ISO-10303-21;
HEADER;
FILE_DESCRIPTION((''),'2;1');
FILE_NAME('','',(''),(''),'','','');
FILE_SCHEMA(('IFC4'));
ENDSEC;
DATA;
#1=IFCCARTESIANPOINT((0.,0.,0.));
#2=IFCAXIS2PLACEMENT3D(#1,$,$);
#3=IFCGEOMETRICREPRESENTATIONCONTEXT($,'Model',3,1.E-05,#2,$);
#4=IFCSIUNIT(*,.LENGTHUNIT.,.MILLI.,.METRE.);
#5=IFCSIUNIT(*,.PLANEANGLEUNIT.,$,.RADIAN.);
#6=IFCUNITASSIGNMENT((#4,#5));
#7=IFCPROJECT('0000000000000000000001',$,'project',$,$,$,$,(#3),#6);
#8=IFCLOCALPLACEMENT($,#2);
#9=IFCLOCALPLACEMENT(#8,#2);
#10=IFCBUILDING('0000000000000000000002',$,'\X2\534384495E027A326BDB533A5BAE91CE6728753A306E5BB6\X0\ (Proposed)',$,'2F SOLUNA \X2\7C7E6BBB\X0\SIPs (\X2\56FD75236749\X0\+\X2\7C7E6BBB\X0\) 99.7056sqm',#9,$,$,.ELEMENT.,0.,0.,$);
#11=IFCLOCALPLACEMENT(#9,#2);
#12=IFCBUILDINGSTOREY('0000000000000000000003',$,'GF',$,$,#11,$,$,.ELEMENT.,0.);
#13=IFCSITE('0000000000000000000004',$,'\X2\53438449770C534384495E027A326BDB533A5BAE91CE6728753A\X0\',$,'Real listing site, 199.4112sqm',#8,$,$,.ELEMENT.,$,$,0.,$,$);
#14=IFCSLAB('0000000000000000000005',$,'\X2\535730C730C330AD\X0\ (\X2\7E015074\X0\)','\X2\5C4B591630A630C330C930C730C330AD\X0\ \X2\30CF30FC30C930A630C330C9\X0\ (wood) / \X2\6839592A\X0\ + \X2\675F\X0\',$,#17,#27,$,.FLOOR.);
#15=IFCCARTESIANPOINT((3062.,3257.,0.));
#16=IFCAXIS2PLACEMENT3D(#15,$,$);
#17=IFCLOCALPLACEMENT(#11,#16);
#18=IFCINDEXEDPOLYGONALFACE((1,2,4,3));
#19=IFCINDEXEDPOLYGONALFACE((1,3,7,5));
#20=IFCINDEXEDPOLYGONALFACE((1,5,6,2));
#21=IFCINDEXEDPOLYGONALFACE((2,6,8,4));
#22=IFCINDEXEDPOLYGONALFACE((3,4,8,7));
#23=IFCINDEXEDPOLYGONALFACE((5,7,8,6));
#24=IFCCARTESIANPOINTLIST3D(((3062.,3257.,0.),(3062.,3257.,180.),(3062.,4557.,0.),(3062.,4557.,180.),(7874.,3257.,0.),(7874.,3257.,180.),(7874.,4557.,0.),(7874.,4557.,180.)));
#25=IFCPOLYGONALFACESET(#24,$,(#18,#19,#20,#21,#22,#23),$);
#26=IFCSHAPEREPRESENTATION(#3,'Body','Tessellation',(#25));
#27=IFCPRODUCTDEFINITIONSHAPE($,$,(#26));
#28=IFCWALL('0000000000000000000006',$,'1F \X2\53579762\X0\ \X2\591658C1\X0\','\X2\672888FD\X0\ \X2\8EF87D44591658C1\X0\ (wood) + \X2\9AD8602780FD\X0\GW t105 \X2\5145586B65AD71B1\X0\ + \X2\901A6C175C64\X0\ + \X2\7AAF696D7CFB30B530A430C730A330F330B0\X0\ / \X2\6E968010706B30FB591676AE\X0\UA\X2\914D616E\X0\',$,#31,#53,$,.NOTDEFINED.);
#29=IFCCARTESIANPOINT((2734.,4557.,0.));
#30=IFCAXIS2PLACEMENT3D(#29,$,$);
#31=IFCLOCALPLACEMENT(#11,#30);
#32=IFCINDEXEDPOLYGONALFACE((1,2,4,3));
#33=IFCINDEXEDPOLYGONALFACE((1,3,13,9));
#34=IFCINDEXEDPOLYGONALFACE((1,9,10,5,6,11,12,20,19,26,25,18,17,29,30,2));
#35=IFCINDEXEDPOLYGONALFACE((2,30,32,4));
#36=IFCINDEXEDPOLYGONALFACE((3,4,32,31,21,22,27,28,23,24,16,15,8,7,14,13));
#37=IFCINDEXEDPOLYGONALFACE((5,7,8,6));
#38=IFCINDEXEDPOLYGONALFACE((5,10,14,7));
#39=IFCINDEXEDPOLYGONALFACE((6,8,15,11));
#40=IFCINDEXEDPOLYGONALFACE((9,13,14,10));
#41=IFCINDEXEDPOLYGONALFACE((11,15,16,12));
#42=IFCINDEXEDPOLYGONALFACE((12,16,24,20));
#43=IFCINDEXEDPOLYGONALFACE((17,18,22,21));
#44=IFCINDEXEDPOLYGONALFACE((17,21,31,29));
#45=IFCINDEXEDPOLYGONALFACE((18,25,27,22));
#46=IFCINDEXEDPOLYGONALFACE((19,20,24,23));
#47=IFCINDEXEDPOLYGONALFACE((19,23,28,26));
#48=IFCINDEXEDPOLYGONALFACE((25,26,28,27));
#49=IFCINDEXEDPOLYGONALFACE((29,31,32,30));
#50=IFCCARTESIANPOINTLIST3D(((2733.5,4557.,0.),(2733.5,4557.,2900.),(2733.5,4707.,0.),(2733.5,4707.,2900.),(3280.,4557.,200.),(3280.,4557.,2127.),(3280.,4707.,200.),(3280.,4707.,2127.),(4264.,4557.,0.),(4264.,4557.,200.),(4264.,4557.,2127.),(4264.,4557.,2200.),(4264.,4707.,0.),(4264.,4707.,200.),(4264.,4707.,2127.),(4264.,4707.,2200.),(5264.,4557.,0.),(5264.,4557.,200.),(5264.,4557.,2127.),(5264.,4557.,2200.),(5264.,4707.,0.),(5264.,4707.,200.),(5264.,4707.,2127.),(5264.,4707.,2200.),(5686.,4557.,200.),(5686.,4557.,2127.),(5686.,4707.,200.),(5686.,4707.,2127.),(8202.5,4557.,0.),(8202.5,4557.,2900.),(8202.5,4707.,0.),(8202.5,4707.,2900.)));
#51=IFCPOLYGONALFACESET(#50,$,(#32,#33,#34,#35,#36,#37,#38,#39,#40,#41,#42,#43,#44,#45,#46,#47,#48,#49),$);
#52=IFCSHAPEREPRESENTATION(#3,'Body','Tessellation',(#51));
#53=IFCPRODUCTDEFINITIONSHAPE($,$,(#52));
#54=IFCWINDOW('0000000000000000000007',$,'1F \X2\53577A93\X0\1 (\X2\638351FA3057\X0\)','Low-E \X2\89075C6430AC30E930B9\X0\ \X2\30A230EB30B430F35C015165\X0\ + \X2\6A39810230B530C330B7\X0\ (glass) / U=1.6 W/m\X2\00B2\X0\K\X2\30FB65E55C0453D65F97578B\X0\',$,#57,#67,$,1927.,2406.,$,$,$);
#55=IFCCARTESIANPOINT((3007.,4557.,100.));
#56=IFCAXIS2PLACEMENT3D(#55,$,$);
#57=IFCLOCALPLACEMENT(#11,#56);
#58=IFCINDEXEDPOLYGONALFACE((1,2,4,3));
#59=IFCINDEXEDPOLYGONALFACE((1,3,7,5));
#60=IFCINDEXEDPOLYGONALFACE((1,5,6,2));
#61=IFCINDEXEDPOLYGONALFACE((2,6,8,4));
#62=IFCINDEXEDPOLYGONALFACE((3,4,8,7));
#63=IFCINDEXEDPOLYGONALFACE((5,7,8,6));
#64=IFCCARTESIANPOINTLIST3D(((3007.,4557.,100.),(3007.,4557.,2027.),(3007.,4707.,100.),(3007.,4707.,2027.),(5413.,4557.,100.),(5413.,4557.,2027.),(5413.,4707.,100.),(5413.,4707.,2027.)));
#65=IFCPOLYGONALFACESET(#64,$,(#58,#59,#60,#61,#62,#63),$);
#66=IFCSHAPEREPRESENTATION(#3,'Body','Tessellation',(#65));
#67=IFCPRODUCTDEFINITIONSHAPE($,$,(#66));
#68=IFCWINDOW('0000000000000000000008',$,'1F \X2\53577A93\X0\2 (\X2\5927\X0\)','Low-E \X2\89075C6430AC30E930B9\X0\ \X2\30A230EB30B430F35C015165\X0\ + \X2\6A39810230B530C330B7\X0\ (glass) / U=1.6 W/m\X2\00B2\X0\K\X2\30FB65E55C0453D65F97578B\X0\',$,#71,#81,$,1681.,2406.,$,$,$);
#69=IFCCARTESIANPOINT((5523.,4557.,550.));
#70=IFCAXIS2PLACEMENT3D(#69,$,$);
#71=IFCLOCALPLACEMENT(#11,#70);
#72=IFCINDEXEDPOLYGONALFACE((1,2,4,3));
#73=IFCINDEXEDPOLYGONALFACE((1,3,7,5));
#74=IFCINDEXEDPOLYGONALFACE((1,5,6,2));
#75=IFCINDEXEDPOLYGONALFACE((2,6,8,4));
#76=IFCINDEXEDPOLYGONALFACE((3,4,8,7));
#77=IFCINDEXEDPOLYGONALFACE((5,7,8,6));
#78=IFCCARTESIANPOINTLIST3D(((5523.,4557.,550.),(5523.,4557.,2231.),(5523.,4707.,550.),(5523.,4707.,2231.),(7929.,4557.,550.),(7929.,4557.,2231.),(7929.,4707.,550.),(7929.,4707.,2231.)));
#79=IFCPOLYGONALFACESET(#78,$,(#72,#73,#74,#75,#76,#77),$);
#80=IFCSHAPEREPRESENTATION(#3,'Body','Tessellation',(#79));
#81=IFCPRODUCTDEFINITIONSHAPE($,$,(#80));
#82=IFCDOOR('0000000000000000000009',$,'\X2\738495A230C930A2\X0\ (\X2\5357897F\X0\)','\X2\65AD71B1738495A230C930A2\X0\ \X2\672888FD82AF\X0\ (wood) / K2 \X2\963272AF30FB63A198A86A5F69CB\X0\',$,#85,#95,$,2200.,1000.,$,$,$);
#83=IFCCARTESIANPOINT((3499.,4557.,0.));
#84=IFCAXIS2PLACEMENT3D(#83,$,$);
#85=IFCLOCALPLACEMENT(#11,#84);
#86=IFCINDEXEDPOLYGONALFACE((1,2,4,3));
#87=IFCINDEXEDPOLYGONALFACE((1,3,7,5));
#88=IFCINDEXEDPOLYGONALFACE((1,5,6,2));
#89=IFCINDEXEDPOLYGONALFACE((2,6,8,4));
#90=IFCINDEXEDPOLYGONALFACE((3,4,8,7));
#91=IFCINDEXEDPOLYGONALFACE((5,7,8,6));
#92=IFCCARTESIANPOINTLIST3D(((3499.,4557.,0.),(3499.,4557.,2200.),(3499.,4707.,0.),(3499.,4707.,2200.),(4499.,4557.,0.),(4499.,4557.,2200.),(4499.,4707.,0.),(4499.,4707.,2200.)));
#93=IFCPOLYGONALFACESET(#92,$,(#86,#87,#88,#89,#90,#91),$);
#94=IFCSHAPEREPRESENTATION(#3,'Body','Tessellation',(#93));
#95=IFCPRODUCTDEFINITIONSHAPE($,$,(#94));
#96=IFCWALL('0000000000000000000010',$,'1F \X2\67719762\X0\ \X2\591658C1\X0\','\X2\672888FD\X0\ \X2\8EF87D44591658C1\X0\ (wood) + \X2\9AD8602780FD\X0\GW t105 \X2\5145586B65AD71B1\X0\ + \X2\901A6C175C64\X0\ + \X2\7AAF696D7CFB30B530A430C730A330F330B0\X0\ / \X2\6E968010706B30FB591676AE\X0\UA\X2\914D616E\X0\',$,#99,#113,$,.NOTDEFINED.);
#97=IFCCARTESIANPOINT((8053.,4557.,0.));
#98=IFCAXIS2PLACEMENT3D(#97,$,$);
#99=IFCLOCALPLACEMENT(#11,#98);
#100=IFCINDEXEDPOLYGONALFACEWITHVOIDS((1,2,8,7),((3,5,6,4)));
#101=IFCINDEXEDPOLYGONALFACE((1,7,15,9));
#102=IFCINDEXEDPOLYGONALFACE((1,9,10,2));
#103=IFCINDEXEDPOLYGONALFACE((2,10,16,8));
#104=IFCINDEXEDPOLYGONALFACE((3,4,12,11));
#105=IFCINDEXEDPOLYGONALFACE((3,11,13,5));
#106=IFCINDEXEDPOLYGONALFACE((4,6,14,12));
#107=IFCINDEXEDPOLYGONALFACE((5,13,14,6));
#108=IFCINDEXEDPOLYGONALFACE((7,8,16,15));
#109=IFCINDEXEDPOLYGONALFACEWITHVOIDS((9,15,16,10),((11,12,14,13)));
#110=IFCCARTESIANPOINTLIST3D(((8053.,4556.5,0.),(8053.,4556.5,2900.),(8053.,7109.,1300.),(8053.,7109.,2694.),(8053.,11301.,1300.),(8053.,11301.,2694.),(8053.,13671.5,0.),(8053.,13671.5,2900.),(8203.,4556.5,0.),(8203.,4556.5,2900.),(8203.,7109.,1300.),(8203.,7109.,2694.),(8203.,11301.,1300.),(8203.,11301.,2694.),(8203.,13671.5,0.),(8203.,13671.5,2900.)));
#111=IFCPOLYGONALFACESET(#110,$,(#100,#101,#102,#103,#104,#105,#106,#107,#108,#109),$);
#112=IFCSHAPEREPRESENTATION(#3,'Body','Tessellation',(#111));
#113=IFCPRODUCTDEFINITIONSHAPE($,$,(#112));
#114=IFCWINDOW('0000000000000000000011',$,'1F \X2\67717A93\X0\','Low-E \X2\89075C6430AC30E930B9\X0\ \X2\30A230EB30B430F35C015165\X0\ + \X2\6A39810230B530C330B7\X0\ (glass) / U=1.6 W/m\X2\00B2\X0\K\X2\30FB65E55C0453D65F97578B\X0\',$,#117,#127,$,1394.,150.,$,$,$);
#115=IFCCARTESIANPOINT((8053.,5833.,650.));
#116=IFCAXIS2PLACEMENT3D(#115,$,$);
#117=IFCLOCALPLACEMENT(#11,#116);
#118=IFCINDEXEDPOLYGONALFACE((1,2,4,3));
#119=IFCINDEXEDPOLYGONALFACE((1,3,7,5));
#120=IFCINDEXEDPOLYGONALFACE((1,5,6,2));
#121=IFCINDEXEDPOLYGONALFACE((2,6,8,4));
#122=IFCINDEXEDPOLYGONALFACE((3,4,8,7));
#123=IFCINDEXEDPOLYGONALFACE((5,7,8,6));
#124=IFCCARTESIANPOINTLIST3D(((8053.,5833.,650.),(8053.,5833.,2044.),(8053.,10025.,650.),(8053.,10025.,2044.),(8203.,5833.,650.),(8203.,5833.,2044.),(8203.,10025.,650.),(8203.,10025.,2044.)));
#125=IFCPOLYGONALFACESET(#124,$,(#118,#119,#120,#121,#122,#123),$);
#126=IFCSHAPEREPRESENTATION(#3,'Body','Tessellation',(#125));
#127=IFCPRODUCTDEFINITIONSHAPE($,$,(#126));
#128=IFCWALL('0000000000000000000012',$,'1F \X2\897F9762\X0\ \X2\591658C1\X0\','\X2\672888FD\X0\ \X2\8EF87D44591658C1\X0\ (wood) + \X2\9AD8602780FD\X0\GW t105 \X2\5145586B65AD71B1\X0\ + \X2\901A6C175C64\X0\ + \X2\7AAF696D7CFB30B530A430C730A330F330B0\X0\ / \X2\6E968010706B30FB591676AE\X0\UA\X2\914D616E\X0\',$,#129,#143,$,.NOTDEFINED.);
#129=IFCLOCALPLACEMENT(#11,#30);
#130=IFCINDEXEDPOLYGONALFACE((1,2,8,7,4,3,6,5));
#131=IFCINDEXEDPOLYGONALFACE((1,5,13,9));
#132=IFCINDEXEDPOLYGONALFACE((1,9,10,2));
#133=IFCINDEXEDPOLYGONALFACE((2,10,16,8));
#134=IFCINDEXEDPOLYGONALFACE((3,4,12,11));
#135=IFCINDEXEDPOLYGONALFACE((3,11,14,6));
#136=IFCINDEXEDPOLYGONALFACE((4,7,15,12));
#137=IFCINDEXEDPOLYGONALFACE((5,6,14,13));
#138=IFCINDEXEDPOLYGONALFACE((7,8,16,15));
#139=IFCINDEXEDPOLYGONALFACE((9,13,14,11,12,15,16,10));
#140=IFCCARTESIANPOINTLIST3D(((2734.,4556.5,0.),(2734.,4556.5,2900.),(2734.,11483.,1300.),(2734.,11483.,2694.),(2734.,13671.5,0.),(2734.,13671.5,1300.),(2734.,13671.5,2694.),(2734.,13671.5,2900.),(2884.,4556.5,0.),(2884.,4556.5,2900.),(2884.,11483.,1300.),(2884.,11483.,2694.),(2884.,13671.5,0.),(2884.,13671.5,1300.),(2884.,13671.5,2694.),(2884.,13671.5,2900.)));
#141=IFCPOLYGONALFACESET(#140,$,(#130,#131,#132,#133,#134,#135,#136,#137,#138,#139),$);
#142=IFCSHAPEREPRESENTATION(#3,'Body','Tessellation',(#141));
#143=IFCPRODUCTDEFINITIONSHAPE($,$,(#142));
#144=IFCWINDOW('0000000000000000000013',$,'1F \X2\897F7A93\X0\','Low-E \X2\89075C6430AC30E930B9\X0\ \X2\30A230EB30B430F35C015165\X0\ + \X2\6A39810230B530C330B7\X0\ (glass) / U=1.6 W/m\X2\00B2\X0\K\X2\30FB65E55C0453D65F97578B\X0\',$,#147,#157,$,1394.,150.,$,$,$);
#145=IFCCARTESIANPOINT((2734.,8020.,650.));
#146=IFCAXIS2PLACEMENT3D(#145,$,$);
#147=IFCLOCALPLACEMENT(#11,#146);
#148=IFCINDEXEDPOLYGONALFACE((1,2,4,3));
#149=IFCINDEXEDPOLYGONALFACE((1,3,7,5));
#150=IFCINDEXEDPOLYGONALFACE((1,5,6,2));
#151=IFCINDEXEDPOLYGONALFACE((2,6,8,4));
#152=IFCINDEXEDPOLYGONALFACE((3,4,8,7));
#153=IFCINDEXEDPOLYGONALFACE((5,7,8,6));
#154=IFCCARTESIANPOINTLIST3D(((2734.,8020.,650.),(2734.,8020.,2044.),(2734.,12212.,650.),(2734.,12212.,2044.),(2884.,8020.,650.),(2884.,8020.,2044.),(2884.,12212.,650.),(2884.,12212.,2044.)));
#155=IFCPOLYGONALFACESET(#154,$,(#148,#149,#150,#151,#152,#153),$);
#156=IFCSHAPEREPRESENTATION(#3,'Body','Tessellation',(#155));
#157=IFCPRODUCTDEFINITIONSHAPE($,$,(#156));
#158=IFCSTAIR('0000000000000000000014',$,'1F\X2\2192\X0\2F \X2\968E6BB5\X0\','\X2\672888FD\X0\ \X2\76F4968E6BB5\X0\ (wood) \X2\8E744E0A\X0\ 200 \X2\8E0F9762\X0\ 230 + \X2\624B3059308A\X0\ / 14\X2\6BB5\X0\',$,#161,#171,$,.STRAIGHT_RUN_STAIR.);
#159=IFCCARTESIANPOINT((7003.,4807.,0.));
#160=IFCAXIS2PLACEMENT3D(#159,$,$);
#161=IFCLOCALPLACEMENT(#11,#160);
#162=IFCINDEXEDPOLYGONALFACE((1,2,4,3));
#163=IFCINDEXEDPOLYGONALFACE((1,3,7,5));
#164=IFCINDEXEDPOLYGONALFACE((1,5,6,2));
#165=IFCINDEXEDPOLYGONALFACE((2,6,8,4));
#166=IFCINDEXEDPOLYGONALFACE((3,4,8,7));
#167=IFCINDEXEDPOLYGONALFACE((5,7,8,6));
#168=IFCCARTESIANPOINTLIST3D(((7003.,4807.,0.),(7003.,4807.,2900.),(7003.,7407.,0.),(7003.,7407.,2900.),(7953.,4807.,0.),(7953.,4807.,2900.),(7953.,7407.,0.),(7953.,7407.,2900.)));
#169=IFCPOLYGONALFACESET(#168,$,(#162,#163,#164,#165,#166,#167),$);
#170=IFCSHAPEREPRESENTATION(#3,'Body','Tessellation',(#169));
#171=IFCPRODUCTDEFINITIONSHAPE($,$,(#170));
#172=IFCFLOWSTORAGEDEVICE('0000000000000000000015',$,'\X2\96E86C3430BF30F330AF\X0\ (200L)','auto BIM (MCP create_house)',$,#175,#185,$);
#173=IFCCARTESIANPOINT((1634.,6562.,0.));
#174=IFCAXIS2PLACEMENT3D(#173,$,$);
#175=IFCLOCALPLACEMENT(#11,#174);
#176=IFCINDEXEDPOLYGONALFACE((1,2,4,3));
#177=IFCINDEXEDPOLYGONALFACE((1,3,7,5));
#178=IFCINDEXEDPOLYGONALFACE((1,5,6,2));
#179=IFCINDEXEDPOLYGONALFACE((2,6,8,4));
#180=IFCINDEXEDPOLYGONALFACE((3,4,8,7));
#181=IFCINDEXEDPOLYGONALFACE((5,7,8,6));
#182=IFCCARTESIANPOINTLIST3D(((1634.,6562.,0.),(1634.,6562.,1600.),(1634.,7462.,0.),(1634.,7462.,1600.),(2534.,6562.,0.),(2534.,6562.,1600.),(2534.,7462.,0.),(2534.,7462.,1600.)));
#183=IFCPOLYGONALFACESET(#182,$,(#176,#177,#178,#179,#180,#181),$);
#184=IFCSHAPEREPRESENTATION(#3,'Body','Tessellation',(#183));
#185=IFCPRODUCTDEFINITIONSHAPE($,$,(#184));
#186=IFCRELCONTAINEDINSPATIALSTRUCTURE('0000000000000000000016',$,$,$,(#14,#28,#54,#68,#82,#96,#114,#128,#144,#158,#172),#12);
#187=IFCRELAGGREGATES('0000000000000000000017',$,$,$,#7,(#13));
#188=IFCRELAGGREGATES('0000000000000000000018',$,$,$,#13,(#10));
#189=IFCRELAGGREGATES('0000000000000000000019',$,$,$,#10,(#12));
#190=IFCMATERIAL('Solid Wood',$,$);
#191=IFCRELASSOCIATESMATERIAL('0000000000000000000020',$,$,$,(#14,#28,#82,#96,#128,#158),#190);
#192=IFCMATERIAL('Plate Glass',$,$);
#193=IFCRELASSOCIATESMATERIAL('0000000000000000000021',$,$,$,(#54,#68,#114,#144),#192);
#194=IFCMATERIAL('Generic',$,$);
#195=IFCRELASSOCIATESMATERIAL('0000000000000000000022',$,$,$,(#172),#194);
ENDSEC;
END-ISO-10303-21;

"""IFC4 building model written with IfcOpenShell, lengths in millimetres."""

from ifc_helpers import new_model, si_unit, frame, frame_2d, origin, place, context, project, spatial, rectangle, extrude, material, element, fill, save


model = new_model("IFC4")

# Units and contexts
model_context = context("Model", 3, precision=1e-05, world=origin())
ifc_project = project(units=[si_unit("LENGTHUNIT", "METRE", prefix="MILLI"), si_unit("PLANEANGLEUNIT", "RADIAN")], contexts=[model_context])

# Site, building, storey
site_placement = place(None, origin())
site = spatial("IfcSite", under=ifc_project, at=site_placement, Name="千葉県千葉市稲毛区宮野木町", ObjectType="Real listing site, 199.4112sqm", CompositionType="ELEMENT", RefElevation=0.0)
building_placement = place(site_placement, origin())
building = spatial("IfcBuilding", under=site, at=building_placement, Name="千葉市稲毛区宮野木町の家 (Proposed)", ObjectType="2F SOLUNA 籾殻SIPs (国産杉+籾殻) 99.7056sqm", CompositionType="ELEMENT", ElevationOfRefHeight=0.0, ElevationOfTerrain=0.0)
storey_placement = place(building_placement, origin())
storey = spatial("IfcBuildingStorey", under=building, at=storey_placement, Name="GF", CompositionType="ELEMENT", Elevation=0.0)

# Slab
ifc_material_1 = material(Name="Solid Wood")
slab_1_placement = place(storey_placement, frame((3062.0, 3257.0, 0.0)))
element("IfcSlab", 1, at=slab_1_placement, inside=storey, material=ifc_material_1, Name="南デッキ (縁側)", Description="屋外ウッドデッキ ハードウッド (wood) / 根太 + 束", PredefinedType="FLOOR", context=model_context, shape_type="SweptSolid", body=[
    extrude(rectangle(XDim=4812.0, YDim=1300.0, at=frame_2d((2406.0, 650.0))), frame((3062.0, 3257.0, 0.0)), (0.0, 0.0, 1.0), 180.0),
])

# Wall, openings, windows, door
wall_1_placement = place(storey_placement, frame((2734.0, 4557.0, 0.0)))
wall_1 = element("IfcWall", 2, at=wall_1_placement, inside=storey, material=ifc_material_1, Name="1F 南面 外壁", Description="木製 軸組外壁 (wood) + 高性能GW t105 充填断熱 + 通気層 + 窯業系サイディング / 準耐火・外皮UA配慮", PredefinedType="NOTDEFINED", context=model_context, shape_type="SweptSolid", body=[
    extrude(rectangle(XDim=5469.0, YDim=150.0, at=frame_2d((2734.0, 75.0))), frame((2734.0, 4557.0, 0.0)), (0.0, 0.0, 1.0), 2900.0),
])
opening_1_placement = place(storey_placement, frame((3007.0, 4557.0, 100.0)))
opening_1 = element("IfcOpeningElement", 3, at=opening_1_placement, cuts=wall_1, PredefinedType="NOTDEFINED", context=model_context, shape_type="SweptSolid", body=[
    extrude(rectangle(XDim=2406.0, YDim=150.0, at=frame_2d((1203.0, 75.0))), frame((3007.0, 4557.0, 100.0)), (0.0, 0.0, 1.0), 1927.0),
])
opening_2_placement = place(storey_placement, frame((5523.0, 4557.0, 550.0)))
opening_2 = element("IfcOpeningElement", 4, at=opening_2_placement, cuts=wall_1, PredefinedType="NOTDEFINED", context=model_context, shape_type="SweptSolid", body=[
    extrude(rectangle(XDim=2406.0, YDim=150.0, at=frame_2d((1203.0, 75.0))), frame((5523.0, 4557.0, 550.0)), (0.0, 0.0, 1.0), 1681.0),
])
opening_3_placement = place(storey_placement, frame((3499.0, 4557.0, 0.0)))
opening_3 = element("IfcOpeningElement", 5, at=opening_3_placement, cuts=wall_1, PredefinedType="NOTDEFINED", context=model_context, shape_type="SweptSolid", body=[
    extrude(rectangle(XDim=1000.0, YDim=150.0, at=frame_2d((500.0, 75.0))), frame((3499.0, 4557.0, 0.0)), (0.0, 0.0, 1.0), 2200.0),
])
ifc_material_2 = material(Name="Plate Glass")
window_1_placement = place(storey_placement, frame((3007.0, 4557.0, 100.0)))
window_1 = element("IfcWindow", 6, at=window_1_placement, inside=storey, material=ifc_material_2, Name="1F 南窓1 (掃出し)", Description="Low-E 複層ガラス アルゴン封入 + 樹脂サッシ (glass) / U=1.6 W/m²K・日射取得型", OverallHeight=1927.0, OverallWidth=2406.0, context=model_context, shape_type="SweptSolid", body=[
    extrude(rectangle(XDim=2406.0, YDim=150.0, at=frame_2d((1203.0, 75.0))), frame((3007.0, 4557.0, 100.0)), (0.0, 0.0, 1.0), 1927.0),
])
fill(opening_1, window_1)
window_2_placement = place(storey_placement, frame((5523.0, 4557.0, 550.0)))
window_2 = element("IfcWindow", 7, at=window_2_placement, inside=storey, material=ifc_material_2, Name="1F 南窓2 (大)", Description="Low-E 複層ガラス アルゴン封入 + 樹脂サッシ (glass) / U=1.6 W/m²K・日射取得型", OverallHeight=1681.0, OverallWidth=2406.0, context=model_context, shape_type="SweptSolid", body=[
    extrude(rectangle(XDim=2406.0, YDim=150.0, at=frame_2d((1203.0, 75.0))), frame((5523.0, 4557.0, 550.0)), (0.0, 0.0, 1.0), 1681.0),
])
fill(opening_2, window_2)
door_placement = place(storey_placement, frame((3499.0, 4557.0, 0.0)))
door = element("IfcDoor", 8, at=door_placement, inside=storey, material=ifc_material_1, Name="玄関ドア (南西)", Description="断熱玄関ドア 木製芯 (wood) / K2 防犯・採風機構", OverallHeight=2200.0, OverallWidth=1000.0, context=model_context, shape_type="SweptSolid", body=[
    extrude(rectangle(XDim=1000.0, YDim=150.0, at=frame_2d((500.0, 75.0))), frame((3499.0, 4557.0, 0.0)), (0.0, 0.0, 1.0), 2200.0),
])
fill(opening_3, door)

# Walls, openings, windows
wall_2_placement = place(storey_placement, frame((8053.0, 4557.0, 0.0)))
wall_2 = element("IfcWall", 9, at=wall_2_placement, inside=storey, material=ifc_material_1, Name="1F 東面 外壁", Description="木製 軸組外壁 (wood) + 高性能GW t105 充填断熱 + 通気層 + 窯業系サイディング / 準耐火・外皮UA配慮", PredefinedType="NOTDEFINED", context=model_context, shape_type="SweptSolid", body=[
    extrude(rectangle(XDim=150.0, YDim=9115.0, at=frame_2d((75.0, 4557.0))), frame((8053.0, 4557.0, 0.0)), (0.0, 0.0, 1.0), 2900.0),
])
opening_4_placement = place(storey_placement, frame((8053.0, 5833.0, 650.0)))
opening_4 = element("IfcOpeningElement", 10, at=opening_4_placement, cuts=wall_2, PredefinedType="NOTDEFINED", context=model_context, shape_type="SweptSolid", body=[
    extrude(rectangle(XDim=150.0, YDim=4192.0, at=frame_2d((75.0, 2096.0))), frame((8053.0, 5833.0, 650.0)), (0.0, 0.0, 1.0), 1394.0),
])
window_3_placement = place(storey_placement, frame((8053.0, 5833.0, 650.0)))
window_3 = element("IfcWindow", 11, at=window_3_placement, inside=storey, material=ifc_material_2, Name="1F 東窓", Description="Low-E 複層ガラス アルゴン封入 + 樹脂サッシ (glass) / U=1.6 W/m²K・日射取得型", OverallHeight=1394.0, OverallWidth=150.0, context=model_context, shape_type="SweptSolid", body=[
    extrude(rectangle(XDim=150.0, YDim=4192.0, at=frame_2d((75.0, 2096.0))), frame((8053.0, 5833.0, 650.0)), (0.0, 0.0, 1.0), 1394.0),
])
fill(opening_4, window_3)
wall_3_placement = place(storey_placement, frame((2734.0, 4557.0, 0.0)))
wall_3 = element("IfcWall", 12, at=wall_3_placement, inside=storey, material=ifc_material_1, Name="1F 西面 外壁", Description="木製 軸組外壁 (wood) + 高性能GW t105 充填断熱 + 通気層 + 窯業系サイディング / 準耐火・外皮UA配慮", PredefinedType="NOTDEFINED", context=model_context, shape_type="SweptSolid", body=[
    extrude(rectangle(XDim=150.0, YDim=9115.0, at=frame_2d((75.0, 4557.0))), frame((2734.0, 4557.0, 0.0)), (0.0, 0.0, 1.0), 2900.0),
])
opening_5_placement = place(storey_placement, frame((2734.0, 8020.0, 650.0)))
opening_5 = element("IfcOpeningElement", 13, at=opening_5_placement, cuts=wall_3, PredefinedType="NOTDEFINED", context=model_context, shape_type="SweptSolid", body=[
    extrude(rectangle(XDim=150.0, YDim=4192.0, at=frame_2d((75.0, 2096.0))), frame((2734.0, 8020.0, 650.0)), (0.0, 0.0, 1.0), 1394.0),
])
window_4_placement = place(storey_placement, frame((2734.0, 8020.0, 650.0)))
window_4 = element("IfcWindow", 14, at=window_4_placement, inside=storey, material=ifc_material_2, Name="1F 西窓", Description="Low-E 複層ガラス アルゴン封入 + 樹脂サッシ (glass) / U=1.6 W/m²K・日射取得型", OverallHeight=1394.0, OverallWidth=150.0, context=model_context, shape_type="SweptSolid", body=[
    extrude(rectangle(XDim=150.0, YDim=4192.0, at=frame_2d((75.0, 2096.0))), frame((2734.0, 8020.0, 650.0)), (0.0, 0.0, 1.0), 1394.0),
])
fill(opening_5, window_4)

# Stair
stair_placement = place(storey_placement, frame((7003.0, 4807.0, 0.0)))
element("IfcStair", 15, at=stair_placement, inside=storey, material=ifc_material_1, Name="1F→2F 階段", Description="木製 直階段 (wood) 蹴上 200 踏面 230 + 手すり / 14段", PredefinedType="STRAIGHT_RUN_STAIR", context=model_context, shape_type="SweptSolid", body=[
    extrude(rectangle(XDim=950.0, YDim=2600.0, at=frame_2d((475.0, 1300.0))), frame((7003.0, 4807.0, 0.0)), (0.0, 0.0, 1.0), 2900.0),
])

# Shared definitions
ifc_material_3 = material(Name="Generic")

# Flow storage device
flow_storage_device_placement = place(storey_placement, frame((1634.0, 6562.0, 0.0)))
element("IfcFlowStorageDevice", 16, at=flow_storage_device_placement, inside=storey, material=ifc_material_3, Name="雨水タンク (200L)", Description="auto BIM (MCP create_house)", context=model_context, shape_type="SweptSolid", body=[
    extrude(rectangle(XDim=900.0, YDim=900.0, at=frame_2d((450.0, 450.0))), frame((1634.0, 6562.0, 0.0)), (0.0, 0.0, 1.0), 1600.0),
])

save(model, "model.ifc")
